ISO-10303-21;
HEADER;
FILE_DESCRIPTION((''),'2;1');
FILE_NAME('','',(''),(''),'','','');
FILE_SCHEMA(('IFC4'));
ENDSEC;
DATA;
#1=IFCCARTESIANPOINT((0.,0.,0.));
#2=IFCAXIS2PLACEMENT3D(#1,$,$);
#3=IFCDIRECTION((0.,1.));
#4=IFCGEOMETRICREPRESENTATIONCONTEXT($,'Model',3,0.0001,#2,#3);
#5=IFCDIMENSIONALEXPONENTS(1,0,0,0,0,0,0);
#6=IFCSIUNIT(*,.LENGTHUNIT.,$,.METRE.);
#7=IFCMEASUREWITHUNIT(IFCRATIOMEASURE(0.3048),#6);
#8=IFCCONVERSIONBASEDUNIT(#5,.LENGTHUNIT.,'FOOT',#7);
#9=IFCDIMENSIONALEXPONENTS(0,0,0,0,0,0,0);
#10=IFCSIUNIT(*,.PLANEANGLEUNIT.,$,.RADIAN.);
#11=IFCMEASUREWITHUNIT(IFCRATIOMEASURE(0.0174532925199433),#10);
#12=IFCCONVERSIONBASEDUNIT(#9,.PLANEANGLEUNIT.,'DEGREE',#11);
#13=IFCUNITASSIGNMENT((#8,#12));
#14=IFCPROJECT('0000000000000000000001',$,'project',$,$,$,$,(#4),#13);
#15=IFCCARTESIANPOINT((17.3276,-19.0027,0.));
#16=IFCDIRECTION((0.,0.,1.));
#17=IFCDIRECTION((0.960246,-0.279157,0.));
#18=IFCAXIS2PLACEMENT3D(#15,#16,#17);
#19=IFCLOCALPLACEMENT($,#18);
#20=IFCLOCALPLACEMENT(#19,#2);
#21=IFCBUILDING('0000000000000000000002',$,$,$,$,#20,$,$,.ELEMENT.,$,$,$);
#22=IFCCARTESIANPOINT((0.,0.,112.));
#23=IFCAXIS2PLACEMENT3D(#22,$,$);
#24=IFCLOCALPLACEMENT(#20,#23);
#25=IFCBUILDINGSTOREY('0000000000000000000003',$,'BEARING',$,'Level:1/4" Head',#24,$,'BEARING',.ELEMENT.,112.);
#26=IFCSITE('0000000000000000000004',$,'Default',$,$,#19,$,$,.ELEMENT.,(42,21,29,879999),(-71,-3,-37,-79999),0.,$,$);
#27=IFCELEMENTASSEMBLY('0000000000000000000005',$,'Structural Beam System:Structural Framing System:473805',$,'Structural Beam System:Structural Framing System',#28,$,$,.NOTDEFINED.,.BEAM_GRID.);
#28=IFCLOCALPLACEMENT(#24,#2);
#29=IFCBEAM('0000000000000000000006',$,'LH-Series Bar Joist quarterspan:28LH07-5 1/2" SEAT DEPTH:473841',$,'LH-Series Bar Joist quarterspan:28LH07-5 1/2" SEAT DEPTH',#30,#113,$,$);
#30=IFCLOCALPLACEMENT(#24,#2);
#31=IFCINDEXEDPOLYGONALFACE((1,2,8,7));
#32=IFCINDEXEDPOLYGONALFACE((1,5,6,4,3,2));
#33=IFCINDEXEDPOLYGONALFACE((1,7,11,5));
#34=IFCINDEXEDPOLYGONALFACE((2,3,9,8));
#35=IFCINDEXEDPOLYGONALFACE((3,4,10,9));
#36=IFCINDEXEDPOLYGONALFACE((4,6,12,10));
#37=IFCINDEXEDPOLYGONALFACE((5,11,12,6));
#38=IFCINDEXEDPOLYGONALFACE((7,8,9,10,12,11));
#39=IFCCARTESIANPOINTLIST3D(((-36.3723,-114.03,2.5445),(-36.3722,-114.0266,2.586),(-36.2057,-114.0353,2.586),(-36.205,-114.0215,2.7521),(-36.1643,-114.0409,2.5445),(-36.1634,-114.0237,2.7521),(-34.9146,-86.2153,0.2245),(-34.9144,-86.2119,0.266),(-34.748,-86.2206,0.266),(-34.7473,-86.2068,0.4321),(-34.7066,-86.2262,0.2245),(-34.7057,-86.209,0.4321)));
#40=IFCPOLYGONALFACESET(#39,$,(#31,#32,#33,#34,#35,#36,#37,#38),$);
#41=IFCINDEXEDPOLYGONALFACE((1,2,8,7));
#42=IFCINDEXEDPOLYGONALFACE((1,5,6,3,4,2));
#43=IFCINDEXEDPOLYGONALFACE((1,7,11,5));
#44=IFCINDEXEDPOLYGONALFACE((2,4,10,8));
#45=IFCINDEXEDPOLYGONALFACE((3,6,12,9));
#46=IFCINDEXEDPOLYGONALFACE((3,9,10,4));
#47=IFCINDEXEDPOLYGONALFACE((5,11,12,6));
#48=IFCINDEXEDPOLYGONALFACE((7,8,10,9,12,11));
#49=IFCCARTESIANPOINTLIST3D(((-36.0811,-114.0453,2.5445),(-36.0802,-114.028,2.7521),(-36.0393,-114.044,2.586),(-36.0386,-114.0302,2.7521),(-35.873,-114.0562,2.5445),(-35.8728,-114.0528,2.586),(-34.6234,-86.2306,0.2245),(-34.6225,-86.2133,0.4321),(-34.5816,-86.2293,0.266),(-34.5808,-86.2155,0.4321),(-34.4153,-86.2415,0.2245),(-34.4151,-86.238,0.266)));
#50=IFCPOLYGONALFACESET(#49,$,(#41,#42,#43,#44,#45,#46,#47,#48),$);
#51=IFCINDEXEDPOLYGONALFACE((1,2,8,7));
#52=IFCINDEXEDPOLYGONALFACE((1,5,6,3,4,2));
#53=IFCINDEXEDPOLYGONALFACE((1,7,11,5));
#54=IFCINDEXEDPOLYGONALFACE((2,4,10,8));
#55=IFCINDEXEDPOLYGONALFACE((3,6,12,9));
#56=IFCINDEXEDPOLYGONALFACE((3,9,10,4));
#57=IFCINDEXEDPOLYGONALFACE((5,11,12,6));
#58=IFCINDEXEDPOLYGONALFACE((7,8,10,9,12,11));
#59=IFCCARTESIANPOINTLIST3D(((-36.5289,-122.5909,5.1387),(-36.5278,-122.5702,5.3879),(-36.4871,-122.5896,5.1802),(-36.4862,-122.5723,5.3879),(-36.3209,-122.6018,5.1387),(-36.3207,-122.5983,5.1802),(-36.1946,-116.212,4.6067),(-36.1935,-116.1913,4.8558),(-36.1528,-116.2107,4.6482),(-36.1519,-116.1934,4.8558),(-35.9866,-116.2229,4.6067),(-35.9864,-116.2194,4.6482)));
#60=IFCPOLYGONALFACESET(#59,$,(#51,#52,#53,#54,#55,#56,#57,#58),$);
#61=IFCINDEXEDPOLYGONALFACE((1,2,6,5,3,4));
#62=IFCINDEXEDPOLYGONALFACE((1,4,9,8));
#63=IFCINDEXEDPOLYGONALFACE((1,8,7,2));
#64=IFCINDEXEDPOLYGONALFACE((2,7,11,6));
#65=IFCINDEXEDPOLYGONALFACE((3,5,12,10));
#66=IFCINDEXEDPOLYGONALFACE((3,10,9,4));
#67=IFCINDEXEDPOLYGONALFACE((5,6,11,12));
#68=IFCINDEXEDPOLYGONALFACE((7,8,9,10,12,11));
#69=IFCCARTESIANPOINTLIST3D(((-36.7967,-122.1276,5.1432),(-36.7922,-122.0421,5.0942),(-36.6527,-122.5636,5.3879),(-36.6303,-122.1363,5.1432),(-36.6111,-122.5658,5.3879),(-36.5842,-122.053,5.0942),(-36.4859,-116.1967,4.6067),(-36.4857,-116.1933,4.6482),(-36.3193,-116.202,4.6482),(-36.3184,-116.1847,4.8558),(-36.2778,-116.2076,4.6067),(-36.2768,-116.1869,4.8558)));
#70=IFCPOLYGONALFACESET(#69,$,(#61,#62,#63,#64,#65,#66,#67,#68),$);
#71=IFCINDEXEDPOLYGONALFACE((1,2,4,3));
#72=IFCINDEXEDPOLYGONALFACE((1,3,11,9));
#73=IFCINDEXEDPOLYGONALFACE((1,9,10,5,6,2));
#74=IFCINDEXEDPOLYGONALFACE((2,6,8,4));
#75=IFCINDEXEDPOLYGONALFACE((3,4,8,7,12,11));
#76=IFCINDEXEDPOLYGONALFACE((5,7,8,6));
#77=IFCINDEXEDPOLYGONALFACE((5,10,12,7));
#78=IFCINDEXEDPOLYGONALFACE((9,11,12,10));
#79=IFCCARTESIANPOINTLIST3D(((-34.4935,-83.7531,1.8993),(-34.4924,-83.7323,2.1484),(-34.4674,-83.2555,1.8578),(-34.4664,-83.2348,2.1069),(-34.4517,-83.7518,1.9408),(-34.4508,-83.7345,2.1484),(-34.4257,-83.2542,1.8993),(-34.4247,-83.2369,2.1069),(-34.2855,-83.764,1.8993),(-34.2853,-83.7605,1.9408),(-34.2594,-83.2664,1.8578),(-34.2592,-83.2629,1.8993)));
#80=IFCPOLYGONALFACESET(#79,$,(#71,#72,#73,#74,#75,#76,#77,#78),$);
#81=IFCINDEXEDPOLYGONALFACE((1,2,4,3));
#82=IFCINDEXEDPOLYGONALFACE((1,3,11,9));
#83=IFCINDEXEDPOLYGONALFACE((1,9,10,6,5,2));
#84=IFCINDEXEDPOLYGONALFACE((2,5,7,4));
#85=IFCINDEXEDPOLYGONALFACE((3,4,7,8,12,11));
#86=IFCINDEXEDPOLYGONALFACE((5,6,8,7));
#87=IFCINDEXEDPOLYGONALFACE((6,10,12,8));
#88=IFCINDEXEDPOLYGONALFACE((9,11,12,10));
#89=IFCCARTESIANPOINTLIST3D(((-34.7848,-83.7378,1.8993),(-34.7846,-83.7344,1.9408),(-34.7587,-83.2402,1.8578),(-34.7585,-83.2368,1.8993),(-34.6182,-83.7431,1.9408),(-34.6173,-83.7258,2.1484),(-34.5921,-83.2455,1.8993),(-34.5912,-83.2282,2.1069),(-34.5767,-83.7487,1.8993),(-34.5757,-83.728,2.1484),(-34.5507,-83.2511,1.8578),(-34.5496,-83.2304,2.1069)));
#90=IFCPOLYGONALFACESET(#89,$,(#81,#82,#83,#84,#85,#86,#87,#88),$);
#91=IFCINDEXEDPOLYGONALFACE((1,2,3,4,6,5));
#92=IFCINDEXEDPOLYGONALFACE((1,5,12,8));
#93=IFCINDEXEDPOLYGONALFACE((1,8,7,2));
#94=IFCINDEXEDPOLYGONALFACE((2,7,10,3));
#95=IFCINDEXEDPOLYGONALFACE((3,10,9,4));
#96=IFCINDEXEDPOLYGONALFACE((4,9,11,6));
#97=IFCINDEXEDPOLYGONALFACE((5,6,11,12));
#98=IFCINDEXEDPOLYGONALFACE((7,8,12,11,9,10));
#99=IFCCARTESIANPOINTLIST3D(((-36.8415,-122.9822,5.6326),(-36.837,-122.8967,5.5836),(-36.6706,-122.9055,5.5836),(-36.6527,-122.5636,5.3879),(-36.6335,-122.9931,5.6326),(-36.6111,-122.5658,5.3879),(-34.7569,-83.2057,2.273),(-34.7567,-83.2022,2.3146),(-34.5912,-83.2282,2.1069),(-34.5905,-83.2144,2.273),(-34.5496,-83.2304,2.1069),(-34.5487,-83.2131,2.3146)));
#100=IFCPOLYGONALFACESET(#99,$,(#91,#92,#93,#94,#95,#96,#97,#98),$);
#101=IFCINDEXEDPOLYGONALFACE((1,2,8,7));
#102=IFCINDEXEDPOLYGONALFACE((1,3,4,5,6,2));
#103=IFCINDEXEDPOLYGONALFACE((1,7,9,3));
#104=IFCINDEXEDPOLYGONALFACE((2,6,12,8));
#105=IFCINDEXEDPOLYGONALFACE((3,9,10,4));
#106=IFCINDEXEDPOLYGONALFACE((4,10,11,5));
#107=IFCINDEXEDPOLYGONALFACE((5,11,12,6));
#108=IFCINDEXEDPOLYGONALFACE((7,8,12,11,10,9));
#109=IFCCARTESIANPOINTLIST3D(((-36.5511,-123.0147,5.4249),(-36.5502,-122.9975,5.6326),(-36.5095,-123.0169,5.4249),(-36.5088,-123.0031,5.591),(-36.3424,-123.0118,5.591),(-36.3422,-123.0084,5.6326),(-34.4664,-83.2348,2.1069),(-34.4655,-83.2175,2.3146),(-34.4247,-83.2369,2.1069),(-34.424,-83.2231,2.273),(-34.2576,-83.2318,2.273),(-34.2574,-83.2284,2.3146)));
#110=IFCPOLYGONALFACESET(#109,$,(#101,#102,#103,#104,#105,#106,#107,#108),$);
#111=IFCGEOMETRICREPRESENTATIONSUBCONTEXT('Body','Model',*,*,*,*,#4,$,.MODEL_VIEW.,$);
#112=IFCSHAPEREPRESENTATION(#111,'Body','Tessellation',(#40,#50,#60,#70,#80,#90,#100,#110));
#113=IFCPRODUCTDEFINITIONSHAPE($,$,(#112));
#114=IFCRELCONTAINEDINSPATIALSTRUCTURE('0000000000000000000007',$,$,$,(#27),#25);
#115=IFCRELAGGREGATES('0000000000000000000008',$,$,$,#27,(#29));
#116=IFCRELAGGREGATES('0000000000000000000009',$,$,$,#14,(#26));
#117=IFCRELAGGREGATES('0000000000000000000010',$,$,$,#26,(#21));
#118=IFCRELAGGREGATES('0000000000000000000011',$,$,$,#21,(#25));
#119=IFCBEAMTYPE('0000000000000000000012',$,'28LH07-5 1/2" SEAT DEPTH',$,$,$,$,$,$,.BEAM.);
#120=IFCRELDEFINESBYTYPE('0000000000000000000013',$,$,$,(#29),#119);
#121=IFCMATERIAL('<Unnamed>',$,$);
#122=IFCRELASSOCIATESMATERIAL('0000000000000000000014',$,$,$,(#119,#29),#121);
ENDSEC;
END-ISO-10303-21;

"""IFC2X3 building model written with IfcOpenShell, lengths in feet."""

from ifc_helpers import new_model, entity, si_unit, converted_unit, direction, frame, origin, place, context, subcontext, project, spatial, polyline, outline, extrude, clip, halfspace, source, transform, mapped, material, type_object, type_shapes, element, aggregate, save


model = new_model("IFC2X3")

# Units and contexts
model_context = context("Model", 3, precision=0.0001, world=origin(), true_north=direction((0.0, 1.0)))
body_context = subcontext(model_context, "Body", "Model", "MODEL_VIEW")
ifc_project = project(units=[converted_unit("LENGTHUNIT", "FOOT", entity("IfcRatioMeasure", 0.3048), si_unit("LENGTHUNIT", "METRE"), dimensions=[1, 0, 0, 0, 0, 0, 0]), converted_unit("PLANEANGLEUNIT", "DEGREE", entity("IfcRatioMeasure", 0.0174532925199433), si_unit("PLANEANGLEUNIT", "RADIAN"), dimensions=[0, 0, 0, 0, 0, 0, 0])], contexts=[model_context])

# Site, building, storey
site_placement = place(None, frame((17.3276, -19.0027, 0.0), z_axis=(0.0, 0.0, 1.0), x_axis=(0.960246, -0.279157, 0.0)))
site = spatial("IfcSite", under=ifc_project, at=site_placement, Name="Default", CompositionType="ELEMENT", RefLatitude=(42, 21, 29, 879999), RefLongitude=(-71, -3, -37, -79999), RefElevation=0.0)
building_placement = place(site_placement, origin())
building = spatial("IfcBuilding", under=site, at=building_placement, CompositionType="ELEMENT")
storey_placement = place(building_placement, frame((0.0, 0.0, 112.0)))
storey = spatial("IfcBuildingStorey", under=building, at=storey_placement, Name="BEARING", ObjectType="Level:1/4\" Head", LongName="BEARING", CompositionType="ELEMENT", Elevation=112.0)

# Shared definitions
ifc_material_1 = material(Name="<Unnamed>")

# Element assembly, beam
assembly_placement = place(storey_placement, origin())
assembly = element("IfcElementAssembly", 1, at=assembly_placement, inside=storey, Name="Structural Beam System:Structural Framing System:473805", ObjectType="Structural Beam System:Structural Framing System", AssemblyPlace="NOTDEFINED", PredefinedType="BEAM_GRID")
beam_type_1 = type_object("IfcBeamType", Name="28LH07-5 1/2\" SEAT DEPTH", PredefinedType="BEAM", material=ifc_material_1)
shared_shape_1 = source(origin(), body_context, "Body", "SweptSolid", [
    extrude(outline(polyline([(-0.0833, -0.0833), (0.125, -0.0833), (0.125, -0.0417), (-0.0417, -0.0417), (-0.0417, 0.125), (-0.0833, 0.125), (-0.0833, -0.0833)])), frame((-34.7894, -86.215, 112.3075), z_axis=(-0.052155, -0.995183, 0.083007), x_axis=(0.004344, 0.082893, 0.996549)), (0.0, 0.0, 1.0), 27.9493),
    extrude(outline(polyline([(-0.125, -0.0417), (-0.125, -0.0833), (0.0833, -0.0833), (0.0833, 0.125), (0.0417, 0.125), (0.0417, -0.0417), (-0.125, -0.0417)])), frame((-34.5398, -86.228, 112.3075), z_axis=(0.052155, 0.995183, -0.083007), x_axis=(-0.99863, 0.052336, 0.0)), (0.0, 0.0, -1.0), 27.9493),
    extrude(outline(polyline([(-0.125, -0.0556), (-0.125, -0.0972), (0.0833, -0.0972), (0.0833, 0.1528), (0.0417, 0.1528), (0.0417, -0.0556), (-0.125, -0.0556)])), frame((-36.111, -116.2083, 116.7036), z_axis=(0.052155, 0.995183, -0.083007), x_axis=(-0.99863, 0.052336, 0.0)), (0.0, 0.0, -1.0), 6.4098),
    clip(extrude(outline(polyline([(-0.0972, -0.0833), (0.1528, -0.0833), (0.1528, -0.0417), (-0.0556, -0.0417), (-0.0556, 0.125), (-0.0972, 0.125), (-0.0972, -0.0833)])), frame((-36.3606, -116.1952, 116.7036), z_axis=(-0.052155, -0.995183, 0.083007), x_axis=(0.004344, 0.082893, 0.996549)), (0.0, 0.0, 1.0), 6.4098), halfspace(frame((-76.514, -120.9071, 117.6348), z_axis=(-0.025981, -0.495743, -0.868081), x_axis=(0.99863, -0.052336, 0.0)), False)),
    extrude(outline(polyline([(-0.0972, -0.125), (-0.0556, -0.125), (-0.0556, 0.0417), (0.1528, 0.0417), (0.1528, 0.0833), (-0.0972, 0.0833), (-0.0972, -0.125)])), frame((-34.3838, -83.2518, 113.9547), z_axis=(-0.052155, -0.995183, 0.083007), x_axis=(0.004344, 0.082893, 0.996549)), (0.0, 0.0, 1.0), 0.5),
    extrude(outline(polyline([(-0.0972, -0.0833), (0.1528, -0.0833), (0.1528, -0.0417), (-0.0556, -0.0417), (-0.0556, 0.125), (-0.0972, 0.125), (-0.0972, -0.0833)])), frame((-34.6335, -83.2387, 113.9547), z_axis=(-0.052155, -0.995183, 0.083007), x_axis=(0.004344, 0.082893, 0.996549)), (0.0, 0.0, 1.0), 0.5),
    clip(extrude(outline(polyline([(-0.0833, -0.0833), (0.125, -0.0833), (0.125, -0.0417), (-0.0417, -0.0417), (-0.0417, 0.125), (-0.0833, 0.125), (-0.0833, -0.0833)])), frame((-34.6323, -83.2157, 114.2315), z_axis=(-0.052155, -0.995183, 0.083007), x_axis=(-0.99863, 0.052336, 0.0)), (0.0, 0.0, 1.0), 39.9725), halfspace(frame((-76.514, -120.9071, 117.6348), z_axis=(-0.025981, -0.495743, -0.868081), x_axis=(0.99863, -0.052336, 0.0)), False)),
    extrude(outline(polyline([(-0.125, -0.0833), (0.0833, -0.0833), (0.0833, 0.125), (0.0417, 0.125), (0.0417, -0.0417), (-0.125, -0.0417), (-0.125, -0.0833)])), frame((-34.3826, -83.2288, 114.2315), z_axis=(-0.052155, -0.995183, 0.083007), x_axis=(-0.99863, 0.052336, 0.0)), (0.0, 0.0, 1.0), 39.9725),
])
type_shapes(beam_type_1, [shared_shape_1])
beam_1_placement = place(assembly_placement, frame((0.0, 0.0, -112.0)))
beam_1 = element("IfcBeam", 2, at=beam_1_placement, type_object=beam_type_1, material=ifc_material_1, Name="LH-Series Bar Joist quarterspan:28LH07-5 1/2\" SEAT DEPTH:473841", ObjectType="LH-Series Bar Joist quarterspan:28LH07-5 1/2\" SEAT DEPTH", context=body_context, shape_type="MappedRepresentation", body=[
    mapped(shared_shape_1, transform((0.0, 0.0, 0.0), scale=1.0)),
])
aggregate(assembly, [beam_1])

save(model, "model.ifc")
